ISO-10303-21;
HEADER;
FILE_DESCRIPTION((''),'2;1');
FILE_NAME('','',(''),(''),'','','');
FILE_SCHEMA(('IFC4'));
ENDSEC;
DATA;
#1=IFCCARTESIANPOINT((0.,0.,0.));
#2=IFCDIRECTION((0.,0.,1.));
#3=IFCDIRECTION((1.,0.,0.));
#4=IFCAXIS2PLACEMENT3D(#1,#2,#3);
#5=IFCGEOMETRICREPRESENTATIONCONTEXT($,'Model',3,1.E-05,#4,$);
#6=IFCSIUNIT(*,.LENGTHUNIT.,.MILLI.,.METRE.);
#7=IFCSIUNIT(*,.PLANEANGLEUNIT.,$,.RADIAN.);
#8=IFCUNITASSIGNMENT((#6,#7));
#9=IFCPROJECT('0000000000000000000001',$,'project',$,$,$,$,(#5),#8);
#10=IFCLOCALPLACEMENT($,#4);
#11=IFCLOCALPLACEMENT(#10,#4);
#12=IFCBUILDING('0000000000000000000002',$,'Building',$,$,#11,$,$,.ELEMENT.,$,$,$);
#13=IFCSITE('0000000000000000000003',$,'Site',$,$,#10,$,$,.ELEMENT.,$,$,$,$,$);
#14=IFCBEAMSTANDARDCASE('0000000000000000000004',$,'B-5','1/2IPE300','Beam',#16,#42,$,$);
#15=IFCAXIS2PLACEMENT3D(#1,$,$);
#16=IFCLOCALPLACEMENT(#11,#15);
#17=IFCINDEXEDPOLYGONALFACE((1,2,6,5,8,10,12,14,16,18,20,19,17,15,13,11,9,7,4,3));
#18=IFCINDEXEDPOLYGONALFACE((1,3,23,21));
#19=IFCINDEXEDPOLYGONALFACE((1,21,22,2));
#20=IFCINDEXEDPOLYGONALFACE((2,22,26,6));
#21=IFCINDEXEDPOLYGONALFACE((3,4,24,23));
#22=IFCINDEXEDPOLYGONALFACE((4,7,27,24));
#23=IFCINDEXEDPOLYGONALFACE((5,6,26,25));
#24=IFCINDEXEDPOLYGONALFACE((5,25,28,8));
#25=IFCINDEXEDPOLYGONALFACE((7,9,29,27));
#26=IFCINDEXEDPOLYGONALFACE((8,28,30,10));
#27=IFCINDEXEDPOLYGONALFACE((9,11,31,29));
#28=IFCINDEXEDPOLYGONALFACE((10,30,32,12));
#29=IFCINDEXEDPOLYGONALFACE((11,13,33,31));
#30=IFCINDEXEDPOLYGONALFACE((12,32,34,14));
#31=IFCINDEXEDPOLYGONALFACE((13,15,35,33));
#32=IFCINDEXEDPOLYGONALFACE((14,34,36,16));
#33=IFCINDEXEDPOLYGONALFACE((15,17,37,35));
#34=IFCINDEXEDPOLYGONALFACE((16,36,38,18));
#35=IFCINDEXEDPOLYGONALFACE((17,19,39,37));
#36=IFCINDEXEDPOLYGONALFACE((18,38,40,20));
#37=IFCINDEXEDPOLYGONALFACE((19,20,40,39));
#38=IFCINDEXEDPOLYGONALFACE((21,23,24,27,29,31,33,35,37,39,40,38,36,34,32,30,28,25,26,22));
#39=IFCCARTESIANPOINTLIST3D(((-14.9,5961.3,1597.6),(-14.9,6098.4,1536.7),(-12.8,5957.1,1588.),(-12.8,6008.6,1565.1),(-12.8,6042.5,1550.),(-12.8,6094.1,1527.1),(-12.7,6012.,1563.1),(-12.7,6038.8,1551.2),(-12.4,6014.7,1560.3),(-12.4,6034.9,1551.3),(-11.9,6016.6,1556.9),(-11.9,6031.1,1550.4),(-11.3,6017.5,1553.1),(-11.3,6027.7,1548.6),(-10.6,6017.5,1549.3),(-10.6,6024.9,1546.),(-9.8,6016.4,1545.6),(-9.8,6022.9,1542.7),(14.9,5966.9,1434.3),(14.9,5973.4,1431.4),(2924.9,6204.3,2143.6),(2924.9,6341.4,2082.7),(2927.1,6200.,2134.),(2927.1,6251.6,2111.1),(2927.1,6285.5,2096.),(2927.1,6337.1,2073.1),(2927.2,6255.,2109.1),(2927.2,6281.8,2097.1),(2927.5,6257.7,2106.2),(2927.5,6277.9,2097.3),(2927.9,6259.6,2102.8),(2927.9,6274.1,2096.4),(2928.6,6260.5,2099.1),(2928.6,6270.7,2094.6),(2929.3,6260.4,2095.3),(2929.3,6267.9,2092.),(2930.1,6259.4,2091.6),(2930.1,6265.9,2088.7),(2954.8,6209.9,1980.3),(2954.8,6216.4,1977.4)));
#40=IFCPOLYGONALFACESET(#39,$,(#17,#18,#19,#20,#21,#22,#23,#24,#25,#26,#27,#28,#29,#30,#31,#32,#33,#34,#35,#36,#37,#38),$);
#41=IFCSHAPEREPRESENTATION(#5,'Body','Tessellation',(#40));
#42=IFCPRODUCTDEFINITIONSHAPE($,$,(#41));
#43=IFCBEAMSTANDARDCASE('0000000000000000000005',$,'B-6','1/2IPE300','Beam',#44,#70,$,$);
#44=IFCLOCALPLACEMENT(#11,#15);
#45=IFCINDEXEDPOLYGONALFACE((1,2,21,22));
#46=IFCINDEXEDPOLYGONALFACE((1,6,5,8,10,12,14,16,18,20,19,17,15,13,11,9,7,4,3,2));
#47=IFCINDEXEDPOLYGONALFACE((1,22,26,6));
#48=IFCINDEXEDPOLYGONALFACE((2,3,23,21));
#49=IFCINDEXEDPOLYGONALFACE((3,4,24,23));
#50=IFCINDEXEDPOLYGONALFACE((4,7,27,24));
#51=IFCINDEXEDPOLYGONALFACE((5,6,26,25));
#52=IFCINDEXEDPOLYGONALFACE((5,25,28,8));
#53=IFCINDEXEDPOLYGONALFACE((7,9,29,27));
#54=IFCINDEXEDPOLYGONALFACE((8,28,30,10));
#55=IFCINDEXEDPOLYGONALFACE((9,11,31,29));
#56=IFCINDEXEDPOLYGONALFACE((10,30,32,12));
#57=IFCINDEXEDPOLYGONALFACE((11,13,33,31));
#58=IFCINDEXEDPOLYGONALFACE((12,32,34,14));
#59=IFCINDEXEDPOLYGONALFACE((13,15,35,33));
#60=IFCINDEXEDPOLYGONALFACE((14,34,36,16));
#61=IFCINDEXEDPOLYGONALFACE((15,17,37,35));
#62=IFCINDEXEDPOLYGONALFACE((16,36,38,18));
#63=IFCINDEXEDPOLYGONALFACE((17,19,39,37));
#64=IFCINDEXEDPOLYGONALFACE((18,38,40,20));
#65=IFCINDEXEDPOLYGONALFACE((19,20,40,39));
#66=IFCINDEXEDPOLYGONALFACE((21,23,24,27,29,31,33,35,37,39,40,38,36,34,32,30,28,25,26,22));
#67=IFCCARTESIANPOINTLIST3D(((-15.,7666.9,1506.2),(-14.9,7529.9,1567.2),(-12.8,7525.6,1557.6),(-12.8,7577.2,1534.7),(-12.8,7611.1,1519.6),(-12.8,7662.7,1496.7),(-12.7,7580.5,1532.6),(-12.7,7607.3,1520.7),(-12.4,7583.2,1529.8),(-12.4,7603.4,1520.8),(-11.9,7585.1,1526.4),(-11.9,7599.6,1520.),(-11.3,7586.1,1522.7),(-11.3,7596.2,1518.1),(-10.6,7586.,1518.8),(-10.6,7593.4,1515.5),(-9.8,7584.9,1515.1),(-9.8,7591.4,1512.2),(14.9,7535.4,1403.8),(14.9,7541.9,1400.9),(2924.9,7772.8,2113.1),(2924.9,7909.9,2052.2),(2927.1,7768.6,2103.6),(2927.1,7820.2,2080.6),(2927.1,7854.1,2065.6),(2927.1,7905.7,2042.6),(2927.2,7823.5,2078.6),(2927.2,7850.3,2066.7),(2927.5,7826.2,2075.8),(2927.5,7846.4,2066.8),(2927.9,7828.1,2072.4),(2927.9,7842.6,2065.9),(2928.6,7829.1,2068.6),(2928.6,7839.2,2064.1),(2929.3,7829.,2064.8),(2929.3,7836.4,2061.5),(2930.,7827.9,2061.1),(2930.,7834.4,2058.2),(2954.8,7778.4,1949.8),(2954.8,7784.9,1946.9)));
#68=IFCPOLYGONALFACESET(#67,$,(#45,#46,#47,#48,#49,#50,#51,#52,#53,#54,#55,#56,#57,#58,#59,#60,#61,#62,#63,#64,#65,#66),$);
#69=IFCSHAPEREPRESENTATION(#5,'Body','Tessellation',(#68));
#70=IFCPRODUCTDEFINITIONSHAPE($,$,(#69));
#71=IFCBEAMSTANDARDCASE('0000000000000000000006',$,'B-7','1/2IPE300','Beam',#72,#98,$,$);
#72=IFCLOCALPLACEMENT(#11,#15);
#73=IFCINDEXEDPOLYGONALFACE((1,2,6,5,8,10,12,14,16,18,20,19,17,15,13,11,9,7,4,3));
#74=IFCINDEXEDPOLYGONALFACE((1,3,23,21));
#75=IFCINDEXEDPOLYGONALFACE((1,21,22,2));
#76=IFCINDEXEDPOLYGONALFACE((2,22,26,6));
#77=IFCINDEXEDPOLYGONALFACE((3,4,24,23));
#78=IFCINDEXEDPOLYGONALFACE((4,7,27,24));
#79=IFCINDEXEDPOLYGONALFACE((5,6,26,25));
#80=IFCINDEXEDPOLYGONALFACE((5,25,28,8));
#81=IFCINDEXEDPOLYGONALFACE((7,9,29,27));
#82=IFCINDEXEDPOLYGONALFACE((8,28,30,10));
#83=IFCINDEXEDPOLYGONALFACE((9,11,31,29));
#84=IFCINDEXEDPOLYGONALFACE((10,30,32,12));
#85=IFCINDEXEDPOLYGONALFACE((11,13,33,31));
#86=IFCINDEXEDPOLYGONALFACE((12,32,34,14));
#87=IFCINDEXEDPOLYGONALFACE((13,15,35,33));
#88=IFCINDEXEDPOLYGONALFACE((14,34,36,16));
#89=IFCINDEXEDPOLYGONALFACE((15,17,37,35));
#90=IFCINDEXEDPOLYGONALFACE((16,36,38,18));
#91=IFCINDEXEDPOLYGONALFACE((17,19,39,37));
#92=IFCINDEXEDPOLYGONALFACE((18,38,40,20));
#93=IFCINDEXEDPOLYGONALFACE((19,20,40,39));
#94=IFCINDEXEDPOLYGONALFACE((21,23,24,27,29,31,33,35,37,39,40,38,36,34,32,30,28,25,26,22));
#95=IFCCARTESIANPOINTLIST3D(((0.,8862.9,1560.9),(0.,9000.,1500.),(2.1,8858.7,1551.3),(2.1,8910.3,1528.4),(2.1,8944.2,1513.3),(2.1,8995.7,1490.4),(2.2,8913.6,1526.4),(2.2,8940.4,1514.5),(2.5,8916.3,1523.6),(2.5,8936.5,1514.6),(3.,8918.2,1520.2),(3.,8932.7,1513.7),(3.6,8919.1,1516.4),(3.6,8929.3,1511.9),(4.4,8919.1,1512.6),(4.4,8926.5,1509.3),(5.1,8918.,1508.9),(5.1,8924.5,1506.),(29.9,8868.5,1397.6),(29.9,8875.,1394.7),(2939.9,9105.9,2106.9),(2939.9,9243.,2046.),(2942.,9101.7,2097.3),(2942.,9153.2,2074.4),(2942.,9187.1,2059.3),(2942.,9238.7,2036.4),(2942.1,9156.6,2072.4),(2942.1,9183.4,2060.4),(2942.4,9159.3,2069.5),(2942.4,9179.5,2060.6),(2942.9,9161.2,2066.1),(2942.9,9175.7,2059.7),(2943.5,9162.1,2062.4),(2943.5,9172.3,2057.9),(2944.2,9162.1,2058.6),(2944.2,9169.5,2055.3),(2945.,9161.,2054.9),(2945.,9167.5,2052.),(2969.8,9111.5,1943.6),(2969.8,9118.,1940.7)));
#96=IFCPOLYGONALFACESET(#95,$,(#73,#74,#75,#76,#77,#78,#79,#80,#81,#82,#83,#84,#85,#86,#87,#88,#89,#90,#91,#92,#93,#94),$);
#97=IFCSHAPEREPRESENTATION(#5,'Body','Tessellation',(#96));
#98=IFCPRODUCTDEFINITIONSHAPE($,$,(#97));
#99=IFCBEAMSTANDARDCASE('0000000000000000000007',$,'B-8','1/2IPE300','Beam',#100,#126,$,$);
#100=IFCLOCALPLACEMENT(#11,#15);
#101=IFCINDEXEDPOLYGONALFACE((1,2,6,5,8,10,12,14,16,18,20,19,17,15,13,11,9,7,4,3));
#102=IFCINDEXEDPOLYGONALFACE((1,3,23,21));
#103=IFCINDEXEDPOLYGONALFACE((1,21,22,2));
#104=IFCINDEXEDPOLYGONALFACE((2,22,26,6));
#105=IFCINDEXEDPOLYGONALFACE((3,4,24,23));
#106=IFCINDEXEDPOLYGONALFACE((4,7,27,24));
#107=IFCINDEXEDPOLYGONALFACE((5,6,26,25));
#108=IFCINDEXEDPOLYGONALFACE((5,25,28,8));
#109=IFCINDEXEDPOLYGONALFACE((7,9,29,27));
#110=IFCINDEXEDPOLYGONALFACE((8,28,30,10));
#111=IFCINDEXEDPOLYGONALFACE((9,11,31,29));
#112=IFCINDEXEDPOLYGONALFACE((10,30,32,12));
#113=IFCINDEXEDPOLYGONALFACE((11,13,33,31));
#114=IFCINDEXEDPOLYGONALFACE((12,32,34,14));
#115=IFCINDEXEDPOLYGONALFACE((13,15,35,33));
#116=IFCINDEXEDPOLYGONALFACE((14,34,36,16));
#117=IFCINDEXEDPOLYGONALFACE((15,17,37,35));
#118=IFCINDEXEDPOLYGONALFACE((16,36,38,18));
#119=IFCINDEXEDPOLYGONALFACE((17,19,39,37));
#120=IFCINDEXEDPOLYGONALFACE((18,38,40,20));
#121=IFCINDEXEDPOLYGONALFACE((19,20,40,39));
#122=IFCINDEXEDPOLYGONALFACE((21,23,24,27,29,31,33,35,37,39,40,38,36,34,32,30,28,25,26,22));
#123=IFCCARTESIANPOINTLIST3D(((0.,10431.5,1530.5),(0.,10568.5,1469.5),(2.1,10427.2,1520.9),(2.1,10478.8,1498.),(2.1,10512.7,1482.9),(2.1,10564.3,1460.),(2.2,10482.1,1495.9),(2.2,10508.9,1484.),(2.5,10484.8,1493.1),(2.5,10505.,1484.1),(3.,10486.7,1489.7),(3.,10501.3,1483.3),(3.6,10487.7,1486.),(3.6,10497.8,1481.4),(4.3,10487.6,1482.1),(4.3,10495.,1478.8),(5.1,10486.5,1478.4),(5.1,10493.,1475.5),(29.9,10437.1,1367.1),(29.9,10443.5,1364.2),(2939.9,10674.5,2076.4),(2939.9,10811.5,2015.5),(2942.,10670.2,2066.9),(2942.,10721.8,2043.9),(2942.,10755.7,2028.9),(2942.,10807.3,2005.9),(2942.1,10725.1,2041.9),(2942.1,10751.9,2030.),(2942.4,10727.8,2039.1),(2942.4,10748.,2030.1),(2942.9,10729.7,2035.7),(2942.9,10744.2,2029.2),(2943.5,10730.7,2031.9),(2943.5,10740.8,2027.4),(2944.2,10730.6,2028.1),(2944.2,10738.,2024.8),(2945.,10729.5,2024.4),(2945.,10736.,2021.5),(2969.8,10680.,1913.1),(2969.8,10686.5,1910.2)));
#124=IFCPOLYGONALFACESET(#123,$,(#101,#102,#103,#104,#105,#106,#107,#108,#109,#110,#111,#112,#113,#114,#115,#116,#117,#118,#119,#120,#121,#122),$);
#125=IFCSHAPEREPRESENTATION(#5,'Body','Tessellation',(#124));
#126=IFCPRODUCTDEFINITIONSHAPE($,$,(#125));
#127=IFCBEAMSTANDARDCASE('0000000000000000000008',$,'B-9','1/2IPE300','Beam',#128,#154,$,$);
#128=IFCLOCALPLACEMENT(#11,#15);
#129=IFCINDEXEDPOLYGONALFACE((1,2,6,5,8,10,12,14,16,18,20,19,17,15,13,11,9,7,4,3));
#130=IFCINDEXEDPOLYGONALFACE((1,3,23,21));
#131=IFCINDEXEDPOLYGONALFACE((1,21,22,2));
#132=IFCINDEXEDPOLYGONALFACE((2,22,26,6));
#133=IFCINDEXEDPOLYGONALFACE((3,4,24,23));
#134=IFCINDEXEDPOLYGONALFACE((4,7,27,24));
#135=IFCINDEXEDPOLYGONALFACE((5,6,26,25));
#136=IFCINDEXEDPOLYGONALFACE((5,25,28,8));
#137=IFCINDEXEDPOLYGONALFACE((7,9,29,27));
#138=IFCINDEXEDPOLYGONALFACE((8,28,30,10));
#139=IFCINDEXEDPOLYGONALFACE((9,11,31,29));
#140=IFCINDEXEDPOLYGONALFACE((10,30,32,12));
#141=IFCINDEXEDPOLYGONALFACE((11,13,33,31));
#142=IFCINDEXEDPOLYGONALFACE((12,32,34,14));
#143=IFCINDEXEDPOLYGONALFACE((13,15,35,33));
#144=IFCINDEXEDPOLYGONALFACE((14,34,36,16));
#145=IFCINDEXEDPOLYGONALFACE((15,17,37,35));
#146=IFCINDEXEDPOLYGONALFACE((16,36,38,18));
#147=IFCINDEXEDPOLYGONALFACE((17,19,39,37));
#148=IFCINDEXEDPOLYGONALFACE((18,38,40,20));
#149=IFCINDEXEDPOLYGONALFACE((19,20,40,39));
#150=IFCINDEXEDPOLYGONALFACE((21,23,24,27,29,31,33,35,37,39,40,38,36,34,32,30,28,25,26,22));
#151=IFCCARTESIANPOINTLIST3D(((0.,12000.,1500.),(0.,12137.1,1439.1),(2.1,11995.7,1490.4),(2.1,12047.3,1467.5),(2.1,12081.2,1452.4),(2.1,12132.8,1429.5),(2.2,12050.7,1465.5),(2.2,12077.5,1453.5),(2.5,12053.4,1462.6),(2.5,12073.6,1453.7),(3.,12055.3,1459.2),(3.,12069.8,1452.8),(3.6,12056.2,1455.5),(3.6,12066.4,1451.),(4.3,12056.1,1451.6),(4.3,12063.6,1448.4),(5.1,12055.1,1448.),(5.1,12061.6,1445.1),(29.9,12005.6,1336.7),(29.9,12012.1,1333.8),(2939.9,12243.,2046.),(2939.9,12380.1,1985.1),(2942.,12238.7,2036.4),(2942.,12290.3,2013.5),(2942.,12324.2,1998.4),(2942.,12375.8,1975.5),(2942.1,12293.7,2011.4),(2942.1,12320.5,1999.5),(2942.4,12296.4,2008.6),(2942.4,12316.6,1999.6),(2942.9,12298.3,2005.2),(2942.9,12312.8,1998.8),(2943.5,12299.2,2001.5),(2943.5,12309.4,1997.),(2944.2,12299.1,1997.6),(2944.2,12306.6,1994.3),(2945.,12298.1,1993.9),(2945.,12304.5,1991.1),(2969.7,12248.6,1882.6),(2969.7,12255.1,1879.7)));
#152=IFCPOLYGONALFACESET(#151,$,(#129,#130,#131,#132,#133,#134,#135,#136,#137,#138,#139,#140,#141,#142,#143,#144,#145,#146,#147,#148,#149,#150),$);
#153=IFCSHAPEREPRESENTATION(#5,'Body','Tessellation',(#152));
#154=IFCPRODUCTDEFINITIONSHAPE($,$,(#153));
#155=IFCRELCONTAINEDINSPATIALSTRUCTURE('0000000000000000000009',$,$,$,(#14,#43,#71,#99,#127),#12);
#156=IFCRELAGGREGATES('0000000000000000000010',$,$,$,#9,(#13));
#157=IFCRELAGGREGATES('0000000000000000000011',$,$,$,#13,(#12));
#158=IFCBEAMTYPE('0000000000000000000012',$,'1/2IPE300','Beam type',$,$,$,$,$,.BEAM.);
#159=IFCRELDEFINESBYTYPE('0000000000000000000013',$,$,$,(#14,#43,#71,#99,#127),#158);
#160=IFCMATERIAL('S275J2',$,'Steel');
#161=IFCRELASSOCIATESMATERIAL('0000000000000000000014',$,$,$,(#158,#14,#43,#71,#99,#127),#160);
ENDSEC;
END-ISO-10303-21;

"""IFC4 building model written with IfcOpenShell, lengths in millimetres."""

from ifc_helpers import new_model, si_unit, frame, origin, origin_with_axes, place, context, project, spatial, t_section, extrude, material, material_profile, profile_set, profile_usage, type_object, element, save


model = new_model("IFC4")

# Units and contexts
model_context = context("Model", 3, precision=1e-05, world=origin_with_axes())
ifc_project = project(units=[si_unit("LENGTHUNIT", "METRE", prefix="MILLI"), si_unit("PLANEANGLEUNIT", "RADIAN")], contexts=[model_context])

# Site, building
site_placement = place(None, origin_with_axes())
site = spatial("IfcSite", under=ifc_project, at=site_placement, Name="Site", CompositionType="ELEMENT")
building_placement = place(site_placement, origin_with_axes())
building = spatial("IfcBuilding", under=site, at=building_placement, Name="Building", CompositionType="ELEMENT")

# Beams
ifc_material_1 = material(Name="S275J2", Category="Steel")
ifc_material_profile_1 = material_profile(ifc_material_1, t_section(Depth=150.0, FlangeWidth=150.0, WebThickness=7.1, FlangeThickness=10.7, FilletRadius=15.0), Name="1/2IPE300")
ifc_profile_set_1 = profile_set([ifc_material_profile_1])
beam_type_1 = type_object("IfcBeamType", Name="1/2IPE300", Description="Beam type", PredefinedType="BEAM", material=ifc_profile_set_1)
ifc_profile_usage_1 = profile_usage(ifc_profile_set_1, cardinal=5)
beam_1_placement = place(building_placement, frame((0.0, 6000.0, 1500.0), z_axis=(0.98, 0.081, 0.182), x_axis=(-0.0001, 0.9138, -0.40616)))
element("IfcBeamStandardCase", 1, at=beam_1_placement, inside=building, type_object=beam_type_1, material=ifc_profile_usage_1, Name="B-5", Description="1/2IPE300", ObjectType="Beam", context=model_context, shape_type="SweptSolid", body=[
    extrude(t_section(Depth=150.0, FlangeWidth=150.0, WebThickness=7.1, FlangeThickness=10.7, FilletRadius=15.0), origin(), (0.0, 0.0, 1.0), 3000.0),
])
ifc_profile_usage_2 = profile_usage(ifc_profile_set_1, cardinal=6)
beam_2_placement = place(building_placement, frame((0.0, 7500.0, 1500.0), z_axis=(0.98, 0.081, 0.182), x_axis=(-0.0001, 0.9138, -0.40616)))
element("IfcBeamStandardCase", 2, at=beam_2_placement, inside=building, type_object=beam_type_1, material=ifc_profile_usage_2, Name="B-6", Description="1/2IPE300", ObjectType="Beam", context=model_context, shape_type="SweptSolid", body=[
    extrude(t_section(Depth=150.0, FlangeWidth=150.0, WebThickness=7.1, FlangeThickness=10.7, FilletRadius=15.0), frame((75.0, 0.0, 0.0)), (0.0, 0.0, 1.0), 3000.0),
])
ifc_profile_usage_3 = profile_usage(ifc_profile_set_1, cardinal=7)
beam_3_placement = place(building_placement, frame((0.0, 9000.0, 1500.0), z_axis=(0.98, 0.081, 0.182), x_axis=(-0.0001, 0.9138, -0.40616)))
element("IfcBeamStandardCase", 3, at=beam_3_placement, inside=building, type_object=beam_type_1, material=ifc_profile_usage_3, Name="B-7", Description="1/2IPE300", ObjectType="Beam", context=model_context, shape_type="SweptSolid", body=[
    extrude(t_section(Depth=150.0, FlangeWidth=150.0, WebThickness=7.1, FlangeThickness=10.7, FilletRadius=15.0), frame((-75.0, -75.0, 0.0)), (0.0, 0.0, 1.0), 3000.0),
])
ifc_profile_usage_4 = profile_usage(ifc_profile_set_1, cardinal=8)
beam_4_placement = place(building_placement, frame((0.0, 10500.0, 1500.0), z_axis=(0.98, 0.081, 0.182), x_axis=(-0.0001, 0.9138, -0.40616)))
element("IfcBeamStandardCase", 4, at=beam_4_placement, inside=building, type_object=beam_type_1, material=ifc_profile_usage_4, Name="B-8", Description="1/2IPE300", ObjectType="Beam", context=model_context, shape_type="SweptSolid", body=[
    extrude(t_section(Depth=150.0, FlangeWidth=150.0, WebThickness=7.1, FlangeThickness=10.7, FilletRadius=15.0), frame((0.0, -75.0, 0.0)), (0.0, 0.0, 1.0), 3000.0),
])
ifc_profile_usage_5 = profile_usage(ifc_profile_set_1, cardinal=9)
beam_5_placement = place(building_placement, frame((0.0, 12000.0, 1500.0), z_axis=(0.98, 0.081, 0.182), x_axis=(-0.0001, 0.9138, -0.40616)))
element("IfcBeamStandardCase", 5, at=beam_5_placement, inside=building, type_object=beam_type_1, material=ifc_profile_usage_5, Name="B-9", Description="1/2IPE300", ObjectType="Beam", context=model_context, shape_type="SweptSolid", body=[
    extrude(t_section(Depth=150.0, FlangeWidth=150.0, WebThickness=7.1, FlangeThickness=10.7, FilletRadius=15.0), frame((75.0, -75.0, 0.0)), (0.0, 0.0, 1.0), 3000.0),
])

save(model, "model.ifc")
